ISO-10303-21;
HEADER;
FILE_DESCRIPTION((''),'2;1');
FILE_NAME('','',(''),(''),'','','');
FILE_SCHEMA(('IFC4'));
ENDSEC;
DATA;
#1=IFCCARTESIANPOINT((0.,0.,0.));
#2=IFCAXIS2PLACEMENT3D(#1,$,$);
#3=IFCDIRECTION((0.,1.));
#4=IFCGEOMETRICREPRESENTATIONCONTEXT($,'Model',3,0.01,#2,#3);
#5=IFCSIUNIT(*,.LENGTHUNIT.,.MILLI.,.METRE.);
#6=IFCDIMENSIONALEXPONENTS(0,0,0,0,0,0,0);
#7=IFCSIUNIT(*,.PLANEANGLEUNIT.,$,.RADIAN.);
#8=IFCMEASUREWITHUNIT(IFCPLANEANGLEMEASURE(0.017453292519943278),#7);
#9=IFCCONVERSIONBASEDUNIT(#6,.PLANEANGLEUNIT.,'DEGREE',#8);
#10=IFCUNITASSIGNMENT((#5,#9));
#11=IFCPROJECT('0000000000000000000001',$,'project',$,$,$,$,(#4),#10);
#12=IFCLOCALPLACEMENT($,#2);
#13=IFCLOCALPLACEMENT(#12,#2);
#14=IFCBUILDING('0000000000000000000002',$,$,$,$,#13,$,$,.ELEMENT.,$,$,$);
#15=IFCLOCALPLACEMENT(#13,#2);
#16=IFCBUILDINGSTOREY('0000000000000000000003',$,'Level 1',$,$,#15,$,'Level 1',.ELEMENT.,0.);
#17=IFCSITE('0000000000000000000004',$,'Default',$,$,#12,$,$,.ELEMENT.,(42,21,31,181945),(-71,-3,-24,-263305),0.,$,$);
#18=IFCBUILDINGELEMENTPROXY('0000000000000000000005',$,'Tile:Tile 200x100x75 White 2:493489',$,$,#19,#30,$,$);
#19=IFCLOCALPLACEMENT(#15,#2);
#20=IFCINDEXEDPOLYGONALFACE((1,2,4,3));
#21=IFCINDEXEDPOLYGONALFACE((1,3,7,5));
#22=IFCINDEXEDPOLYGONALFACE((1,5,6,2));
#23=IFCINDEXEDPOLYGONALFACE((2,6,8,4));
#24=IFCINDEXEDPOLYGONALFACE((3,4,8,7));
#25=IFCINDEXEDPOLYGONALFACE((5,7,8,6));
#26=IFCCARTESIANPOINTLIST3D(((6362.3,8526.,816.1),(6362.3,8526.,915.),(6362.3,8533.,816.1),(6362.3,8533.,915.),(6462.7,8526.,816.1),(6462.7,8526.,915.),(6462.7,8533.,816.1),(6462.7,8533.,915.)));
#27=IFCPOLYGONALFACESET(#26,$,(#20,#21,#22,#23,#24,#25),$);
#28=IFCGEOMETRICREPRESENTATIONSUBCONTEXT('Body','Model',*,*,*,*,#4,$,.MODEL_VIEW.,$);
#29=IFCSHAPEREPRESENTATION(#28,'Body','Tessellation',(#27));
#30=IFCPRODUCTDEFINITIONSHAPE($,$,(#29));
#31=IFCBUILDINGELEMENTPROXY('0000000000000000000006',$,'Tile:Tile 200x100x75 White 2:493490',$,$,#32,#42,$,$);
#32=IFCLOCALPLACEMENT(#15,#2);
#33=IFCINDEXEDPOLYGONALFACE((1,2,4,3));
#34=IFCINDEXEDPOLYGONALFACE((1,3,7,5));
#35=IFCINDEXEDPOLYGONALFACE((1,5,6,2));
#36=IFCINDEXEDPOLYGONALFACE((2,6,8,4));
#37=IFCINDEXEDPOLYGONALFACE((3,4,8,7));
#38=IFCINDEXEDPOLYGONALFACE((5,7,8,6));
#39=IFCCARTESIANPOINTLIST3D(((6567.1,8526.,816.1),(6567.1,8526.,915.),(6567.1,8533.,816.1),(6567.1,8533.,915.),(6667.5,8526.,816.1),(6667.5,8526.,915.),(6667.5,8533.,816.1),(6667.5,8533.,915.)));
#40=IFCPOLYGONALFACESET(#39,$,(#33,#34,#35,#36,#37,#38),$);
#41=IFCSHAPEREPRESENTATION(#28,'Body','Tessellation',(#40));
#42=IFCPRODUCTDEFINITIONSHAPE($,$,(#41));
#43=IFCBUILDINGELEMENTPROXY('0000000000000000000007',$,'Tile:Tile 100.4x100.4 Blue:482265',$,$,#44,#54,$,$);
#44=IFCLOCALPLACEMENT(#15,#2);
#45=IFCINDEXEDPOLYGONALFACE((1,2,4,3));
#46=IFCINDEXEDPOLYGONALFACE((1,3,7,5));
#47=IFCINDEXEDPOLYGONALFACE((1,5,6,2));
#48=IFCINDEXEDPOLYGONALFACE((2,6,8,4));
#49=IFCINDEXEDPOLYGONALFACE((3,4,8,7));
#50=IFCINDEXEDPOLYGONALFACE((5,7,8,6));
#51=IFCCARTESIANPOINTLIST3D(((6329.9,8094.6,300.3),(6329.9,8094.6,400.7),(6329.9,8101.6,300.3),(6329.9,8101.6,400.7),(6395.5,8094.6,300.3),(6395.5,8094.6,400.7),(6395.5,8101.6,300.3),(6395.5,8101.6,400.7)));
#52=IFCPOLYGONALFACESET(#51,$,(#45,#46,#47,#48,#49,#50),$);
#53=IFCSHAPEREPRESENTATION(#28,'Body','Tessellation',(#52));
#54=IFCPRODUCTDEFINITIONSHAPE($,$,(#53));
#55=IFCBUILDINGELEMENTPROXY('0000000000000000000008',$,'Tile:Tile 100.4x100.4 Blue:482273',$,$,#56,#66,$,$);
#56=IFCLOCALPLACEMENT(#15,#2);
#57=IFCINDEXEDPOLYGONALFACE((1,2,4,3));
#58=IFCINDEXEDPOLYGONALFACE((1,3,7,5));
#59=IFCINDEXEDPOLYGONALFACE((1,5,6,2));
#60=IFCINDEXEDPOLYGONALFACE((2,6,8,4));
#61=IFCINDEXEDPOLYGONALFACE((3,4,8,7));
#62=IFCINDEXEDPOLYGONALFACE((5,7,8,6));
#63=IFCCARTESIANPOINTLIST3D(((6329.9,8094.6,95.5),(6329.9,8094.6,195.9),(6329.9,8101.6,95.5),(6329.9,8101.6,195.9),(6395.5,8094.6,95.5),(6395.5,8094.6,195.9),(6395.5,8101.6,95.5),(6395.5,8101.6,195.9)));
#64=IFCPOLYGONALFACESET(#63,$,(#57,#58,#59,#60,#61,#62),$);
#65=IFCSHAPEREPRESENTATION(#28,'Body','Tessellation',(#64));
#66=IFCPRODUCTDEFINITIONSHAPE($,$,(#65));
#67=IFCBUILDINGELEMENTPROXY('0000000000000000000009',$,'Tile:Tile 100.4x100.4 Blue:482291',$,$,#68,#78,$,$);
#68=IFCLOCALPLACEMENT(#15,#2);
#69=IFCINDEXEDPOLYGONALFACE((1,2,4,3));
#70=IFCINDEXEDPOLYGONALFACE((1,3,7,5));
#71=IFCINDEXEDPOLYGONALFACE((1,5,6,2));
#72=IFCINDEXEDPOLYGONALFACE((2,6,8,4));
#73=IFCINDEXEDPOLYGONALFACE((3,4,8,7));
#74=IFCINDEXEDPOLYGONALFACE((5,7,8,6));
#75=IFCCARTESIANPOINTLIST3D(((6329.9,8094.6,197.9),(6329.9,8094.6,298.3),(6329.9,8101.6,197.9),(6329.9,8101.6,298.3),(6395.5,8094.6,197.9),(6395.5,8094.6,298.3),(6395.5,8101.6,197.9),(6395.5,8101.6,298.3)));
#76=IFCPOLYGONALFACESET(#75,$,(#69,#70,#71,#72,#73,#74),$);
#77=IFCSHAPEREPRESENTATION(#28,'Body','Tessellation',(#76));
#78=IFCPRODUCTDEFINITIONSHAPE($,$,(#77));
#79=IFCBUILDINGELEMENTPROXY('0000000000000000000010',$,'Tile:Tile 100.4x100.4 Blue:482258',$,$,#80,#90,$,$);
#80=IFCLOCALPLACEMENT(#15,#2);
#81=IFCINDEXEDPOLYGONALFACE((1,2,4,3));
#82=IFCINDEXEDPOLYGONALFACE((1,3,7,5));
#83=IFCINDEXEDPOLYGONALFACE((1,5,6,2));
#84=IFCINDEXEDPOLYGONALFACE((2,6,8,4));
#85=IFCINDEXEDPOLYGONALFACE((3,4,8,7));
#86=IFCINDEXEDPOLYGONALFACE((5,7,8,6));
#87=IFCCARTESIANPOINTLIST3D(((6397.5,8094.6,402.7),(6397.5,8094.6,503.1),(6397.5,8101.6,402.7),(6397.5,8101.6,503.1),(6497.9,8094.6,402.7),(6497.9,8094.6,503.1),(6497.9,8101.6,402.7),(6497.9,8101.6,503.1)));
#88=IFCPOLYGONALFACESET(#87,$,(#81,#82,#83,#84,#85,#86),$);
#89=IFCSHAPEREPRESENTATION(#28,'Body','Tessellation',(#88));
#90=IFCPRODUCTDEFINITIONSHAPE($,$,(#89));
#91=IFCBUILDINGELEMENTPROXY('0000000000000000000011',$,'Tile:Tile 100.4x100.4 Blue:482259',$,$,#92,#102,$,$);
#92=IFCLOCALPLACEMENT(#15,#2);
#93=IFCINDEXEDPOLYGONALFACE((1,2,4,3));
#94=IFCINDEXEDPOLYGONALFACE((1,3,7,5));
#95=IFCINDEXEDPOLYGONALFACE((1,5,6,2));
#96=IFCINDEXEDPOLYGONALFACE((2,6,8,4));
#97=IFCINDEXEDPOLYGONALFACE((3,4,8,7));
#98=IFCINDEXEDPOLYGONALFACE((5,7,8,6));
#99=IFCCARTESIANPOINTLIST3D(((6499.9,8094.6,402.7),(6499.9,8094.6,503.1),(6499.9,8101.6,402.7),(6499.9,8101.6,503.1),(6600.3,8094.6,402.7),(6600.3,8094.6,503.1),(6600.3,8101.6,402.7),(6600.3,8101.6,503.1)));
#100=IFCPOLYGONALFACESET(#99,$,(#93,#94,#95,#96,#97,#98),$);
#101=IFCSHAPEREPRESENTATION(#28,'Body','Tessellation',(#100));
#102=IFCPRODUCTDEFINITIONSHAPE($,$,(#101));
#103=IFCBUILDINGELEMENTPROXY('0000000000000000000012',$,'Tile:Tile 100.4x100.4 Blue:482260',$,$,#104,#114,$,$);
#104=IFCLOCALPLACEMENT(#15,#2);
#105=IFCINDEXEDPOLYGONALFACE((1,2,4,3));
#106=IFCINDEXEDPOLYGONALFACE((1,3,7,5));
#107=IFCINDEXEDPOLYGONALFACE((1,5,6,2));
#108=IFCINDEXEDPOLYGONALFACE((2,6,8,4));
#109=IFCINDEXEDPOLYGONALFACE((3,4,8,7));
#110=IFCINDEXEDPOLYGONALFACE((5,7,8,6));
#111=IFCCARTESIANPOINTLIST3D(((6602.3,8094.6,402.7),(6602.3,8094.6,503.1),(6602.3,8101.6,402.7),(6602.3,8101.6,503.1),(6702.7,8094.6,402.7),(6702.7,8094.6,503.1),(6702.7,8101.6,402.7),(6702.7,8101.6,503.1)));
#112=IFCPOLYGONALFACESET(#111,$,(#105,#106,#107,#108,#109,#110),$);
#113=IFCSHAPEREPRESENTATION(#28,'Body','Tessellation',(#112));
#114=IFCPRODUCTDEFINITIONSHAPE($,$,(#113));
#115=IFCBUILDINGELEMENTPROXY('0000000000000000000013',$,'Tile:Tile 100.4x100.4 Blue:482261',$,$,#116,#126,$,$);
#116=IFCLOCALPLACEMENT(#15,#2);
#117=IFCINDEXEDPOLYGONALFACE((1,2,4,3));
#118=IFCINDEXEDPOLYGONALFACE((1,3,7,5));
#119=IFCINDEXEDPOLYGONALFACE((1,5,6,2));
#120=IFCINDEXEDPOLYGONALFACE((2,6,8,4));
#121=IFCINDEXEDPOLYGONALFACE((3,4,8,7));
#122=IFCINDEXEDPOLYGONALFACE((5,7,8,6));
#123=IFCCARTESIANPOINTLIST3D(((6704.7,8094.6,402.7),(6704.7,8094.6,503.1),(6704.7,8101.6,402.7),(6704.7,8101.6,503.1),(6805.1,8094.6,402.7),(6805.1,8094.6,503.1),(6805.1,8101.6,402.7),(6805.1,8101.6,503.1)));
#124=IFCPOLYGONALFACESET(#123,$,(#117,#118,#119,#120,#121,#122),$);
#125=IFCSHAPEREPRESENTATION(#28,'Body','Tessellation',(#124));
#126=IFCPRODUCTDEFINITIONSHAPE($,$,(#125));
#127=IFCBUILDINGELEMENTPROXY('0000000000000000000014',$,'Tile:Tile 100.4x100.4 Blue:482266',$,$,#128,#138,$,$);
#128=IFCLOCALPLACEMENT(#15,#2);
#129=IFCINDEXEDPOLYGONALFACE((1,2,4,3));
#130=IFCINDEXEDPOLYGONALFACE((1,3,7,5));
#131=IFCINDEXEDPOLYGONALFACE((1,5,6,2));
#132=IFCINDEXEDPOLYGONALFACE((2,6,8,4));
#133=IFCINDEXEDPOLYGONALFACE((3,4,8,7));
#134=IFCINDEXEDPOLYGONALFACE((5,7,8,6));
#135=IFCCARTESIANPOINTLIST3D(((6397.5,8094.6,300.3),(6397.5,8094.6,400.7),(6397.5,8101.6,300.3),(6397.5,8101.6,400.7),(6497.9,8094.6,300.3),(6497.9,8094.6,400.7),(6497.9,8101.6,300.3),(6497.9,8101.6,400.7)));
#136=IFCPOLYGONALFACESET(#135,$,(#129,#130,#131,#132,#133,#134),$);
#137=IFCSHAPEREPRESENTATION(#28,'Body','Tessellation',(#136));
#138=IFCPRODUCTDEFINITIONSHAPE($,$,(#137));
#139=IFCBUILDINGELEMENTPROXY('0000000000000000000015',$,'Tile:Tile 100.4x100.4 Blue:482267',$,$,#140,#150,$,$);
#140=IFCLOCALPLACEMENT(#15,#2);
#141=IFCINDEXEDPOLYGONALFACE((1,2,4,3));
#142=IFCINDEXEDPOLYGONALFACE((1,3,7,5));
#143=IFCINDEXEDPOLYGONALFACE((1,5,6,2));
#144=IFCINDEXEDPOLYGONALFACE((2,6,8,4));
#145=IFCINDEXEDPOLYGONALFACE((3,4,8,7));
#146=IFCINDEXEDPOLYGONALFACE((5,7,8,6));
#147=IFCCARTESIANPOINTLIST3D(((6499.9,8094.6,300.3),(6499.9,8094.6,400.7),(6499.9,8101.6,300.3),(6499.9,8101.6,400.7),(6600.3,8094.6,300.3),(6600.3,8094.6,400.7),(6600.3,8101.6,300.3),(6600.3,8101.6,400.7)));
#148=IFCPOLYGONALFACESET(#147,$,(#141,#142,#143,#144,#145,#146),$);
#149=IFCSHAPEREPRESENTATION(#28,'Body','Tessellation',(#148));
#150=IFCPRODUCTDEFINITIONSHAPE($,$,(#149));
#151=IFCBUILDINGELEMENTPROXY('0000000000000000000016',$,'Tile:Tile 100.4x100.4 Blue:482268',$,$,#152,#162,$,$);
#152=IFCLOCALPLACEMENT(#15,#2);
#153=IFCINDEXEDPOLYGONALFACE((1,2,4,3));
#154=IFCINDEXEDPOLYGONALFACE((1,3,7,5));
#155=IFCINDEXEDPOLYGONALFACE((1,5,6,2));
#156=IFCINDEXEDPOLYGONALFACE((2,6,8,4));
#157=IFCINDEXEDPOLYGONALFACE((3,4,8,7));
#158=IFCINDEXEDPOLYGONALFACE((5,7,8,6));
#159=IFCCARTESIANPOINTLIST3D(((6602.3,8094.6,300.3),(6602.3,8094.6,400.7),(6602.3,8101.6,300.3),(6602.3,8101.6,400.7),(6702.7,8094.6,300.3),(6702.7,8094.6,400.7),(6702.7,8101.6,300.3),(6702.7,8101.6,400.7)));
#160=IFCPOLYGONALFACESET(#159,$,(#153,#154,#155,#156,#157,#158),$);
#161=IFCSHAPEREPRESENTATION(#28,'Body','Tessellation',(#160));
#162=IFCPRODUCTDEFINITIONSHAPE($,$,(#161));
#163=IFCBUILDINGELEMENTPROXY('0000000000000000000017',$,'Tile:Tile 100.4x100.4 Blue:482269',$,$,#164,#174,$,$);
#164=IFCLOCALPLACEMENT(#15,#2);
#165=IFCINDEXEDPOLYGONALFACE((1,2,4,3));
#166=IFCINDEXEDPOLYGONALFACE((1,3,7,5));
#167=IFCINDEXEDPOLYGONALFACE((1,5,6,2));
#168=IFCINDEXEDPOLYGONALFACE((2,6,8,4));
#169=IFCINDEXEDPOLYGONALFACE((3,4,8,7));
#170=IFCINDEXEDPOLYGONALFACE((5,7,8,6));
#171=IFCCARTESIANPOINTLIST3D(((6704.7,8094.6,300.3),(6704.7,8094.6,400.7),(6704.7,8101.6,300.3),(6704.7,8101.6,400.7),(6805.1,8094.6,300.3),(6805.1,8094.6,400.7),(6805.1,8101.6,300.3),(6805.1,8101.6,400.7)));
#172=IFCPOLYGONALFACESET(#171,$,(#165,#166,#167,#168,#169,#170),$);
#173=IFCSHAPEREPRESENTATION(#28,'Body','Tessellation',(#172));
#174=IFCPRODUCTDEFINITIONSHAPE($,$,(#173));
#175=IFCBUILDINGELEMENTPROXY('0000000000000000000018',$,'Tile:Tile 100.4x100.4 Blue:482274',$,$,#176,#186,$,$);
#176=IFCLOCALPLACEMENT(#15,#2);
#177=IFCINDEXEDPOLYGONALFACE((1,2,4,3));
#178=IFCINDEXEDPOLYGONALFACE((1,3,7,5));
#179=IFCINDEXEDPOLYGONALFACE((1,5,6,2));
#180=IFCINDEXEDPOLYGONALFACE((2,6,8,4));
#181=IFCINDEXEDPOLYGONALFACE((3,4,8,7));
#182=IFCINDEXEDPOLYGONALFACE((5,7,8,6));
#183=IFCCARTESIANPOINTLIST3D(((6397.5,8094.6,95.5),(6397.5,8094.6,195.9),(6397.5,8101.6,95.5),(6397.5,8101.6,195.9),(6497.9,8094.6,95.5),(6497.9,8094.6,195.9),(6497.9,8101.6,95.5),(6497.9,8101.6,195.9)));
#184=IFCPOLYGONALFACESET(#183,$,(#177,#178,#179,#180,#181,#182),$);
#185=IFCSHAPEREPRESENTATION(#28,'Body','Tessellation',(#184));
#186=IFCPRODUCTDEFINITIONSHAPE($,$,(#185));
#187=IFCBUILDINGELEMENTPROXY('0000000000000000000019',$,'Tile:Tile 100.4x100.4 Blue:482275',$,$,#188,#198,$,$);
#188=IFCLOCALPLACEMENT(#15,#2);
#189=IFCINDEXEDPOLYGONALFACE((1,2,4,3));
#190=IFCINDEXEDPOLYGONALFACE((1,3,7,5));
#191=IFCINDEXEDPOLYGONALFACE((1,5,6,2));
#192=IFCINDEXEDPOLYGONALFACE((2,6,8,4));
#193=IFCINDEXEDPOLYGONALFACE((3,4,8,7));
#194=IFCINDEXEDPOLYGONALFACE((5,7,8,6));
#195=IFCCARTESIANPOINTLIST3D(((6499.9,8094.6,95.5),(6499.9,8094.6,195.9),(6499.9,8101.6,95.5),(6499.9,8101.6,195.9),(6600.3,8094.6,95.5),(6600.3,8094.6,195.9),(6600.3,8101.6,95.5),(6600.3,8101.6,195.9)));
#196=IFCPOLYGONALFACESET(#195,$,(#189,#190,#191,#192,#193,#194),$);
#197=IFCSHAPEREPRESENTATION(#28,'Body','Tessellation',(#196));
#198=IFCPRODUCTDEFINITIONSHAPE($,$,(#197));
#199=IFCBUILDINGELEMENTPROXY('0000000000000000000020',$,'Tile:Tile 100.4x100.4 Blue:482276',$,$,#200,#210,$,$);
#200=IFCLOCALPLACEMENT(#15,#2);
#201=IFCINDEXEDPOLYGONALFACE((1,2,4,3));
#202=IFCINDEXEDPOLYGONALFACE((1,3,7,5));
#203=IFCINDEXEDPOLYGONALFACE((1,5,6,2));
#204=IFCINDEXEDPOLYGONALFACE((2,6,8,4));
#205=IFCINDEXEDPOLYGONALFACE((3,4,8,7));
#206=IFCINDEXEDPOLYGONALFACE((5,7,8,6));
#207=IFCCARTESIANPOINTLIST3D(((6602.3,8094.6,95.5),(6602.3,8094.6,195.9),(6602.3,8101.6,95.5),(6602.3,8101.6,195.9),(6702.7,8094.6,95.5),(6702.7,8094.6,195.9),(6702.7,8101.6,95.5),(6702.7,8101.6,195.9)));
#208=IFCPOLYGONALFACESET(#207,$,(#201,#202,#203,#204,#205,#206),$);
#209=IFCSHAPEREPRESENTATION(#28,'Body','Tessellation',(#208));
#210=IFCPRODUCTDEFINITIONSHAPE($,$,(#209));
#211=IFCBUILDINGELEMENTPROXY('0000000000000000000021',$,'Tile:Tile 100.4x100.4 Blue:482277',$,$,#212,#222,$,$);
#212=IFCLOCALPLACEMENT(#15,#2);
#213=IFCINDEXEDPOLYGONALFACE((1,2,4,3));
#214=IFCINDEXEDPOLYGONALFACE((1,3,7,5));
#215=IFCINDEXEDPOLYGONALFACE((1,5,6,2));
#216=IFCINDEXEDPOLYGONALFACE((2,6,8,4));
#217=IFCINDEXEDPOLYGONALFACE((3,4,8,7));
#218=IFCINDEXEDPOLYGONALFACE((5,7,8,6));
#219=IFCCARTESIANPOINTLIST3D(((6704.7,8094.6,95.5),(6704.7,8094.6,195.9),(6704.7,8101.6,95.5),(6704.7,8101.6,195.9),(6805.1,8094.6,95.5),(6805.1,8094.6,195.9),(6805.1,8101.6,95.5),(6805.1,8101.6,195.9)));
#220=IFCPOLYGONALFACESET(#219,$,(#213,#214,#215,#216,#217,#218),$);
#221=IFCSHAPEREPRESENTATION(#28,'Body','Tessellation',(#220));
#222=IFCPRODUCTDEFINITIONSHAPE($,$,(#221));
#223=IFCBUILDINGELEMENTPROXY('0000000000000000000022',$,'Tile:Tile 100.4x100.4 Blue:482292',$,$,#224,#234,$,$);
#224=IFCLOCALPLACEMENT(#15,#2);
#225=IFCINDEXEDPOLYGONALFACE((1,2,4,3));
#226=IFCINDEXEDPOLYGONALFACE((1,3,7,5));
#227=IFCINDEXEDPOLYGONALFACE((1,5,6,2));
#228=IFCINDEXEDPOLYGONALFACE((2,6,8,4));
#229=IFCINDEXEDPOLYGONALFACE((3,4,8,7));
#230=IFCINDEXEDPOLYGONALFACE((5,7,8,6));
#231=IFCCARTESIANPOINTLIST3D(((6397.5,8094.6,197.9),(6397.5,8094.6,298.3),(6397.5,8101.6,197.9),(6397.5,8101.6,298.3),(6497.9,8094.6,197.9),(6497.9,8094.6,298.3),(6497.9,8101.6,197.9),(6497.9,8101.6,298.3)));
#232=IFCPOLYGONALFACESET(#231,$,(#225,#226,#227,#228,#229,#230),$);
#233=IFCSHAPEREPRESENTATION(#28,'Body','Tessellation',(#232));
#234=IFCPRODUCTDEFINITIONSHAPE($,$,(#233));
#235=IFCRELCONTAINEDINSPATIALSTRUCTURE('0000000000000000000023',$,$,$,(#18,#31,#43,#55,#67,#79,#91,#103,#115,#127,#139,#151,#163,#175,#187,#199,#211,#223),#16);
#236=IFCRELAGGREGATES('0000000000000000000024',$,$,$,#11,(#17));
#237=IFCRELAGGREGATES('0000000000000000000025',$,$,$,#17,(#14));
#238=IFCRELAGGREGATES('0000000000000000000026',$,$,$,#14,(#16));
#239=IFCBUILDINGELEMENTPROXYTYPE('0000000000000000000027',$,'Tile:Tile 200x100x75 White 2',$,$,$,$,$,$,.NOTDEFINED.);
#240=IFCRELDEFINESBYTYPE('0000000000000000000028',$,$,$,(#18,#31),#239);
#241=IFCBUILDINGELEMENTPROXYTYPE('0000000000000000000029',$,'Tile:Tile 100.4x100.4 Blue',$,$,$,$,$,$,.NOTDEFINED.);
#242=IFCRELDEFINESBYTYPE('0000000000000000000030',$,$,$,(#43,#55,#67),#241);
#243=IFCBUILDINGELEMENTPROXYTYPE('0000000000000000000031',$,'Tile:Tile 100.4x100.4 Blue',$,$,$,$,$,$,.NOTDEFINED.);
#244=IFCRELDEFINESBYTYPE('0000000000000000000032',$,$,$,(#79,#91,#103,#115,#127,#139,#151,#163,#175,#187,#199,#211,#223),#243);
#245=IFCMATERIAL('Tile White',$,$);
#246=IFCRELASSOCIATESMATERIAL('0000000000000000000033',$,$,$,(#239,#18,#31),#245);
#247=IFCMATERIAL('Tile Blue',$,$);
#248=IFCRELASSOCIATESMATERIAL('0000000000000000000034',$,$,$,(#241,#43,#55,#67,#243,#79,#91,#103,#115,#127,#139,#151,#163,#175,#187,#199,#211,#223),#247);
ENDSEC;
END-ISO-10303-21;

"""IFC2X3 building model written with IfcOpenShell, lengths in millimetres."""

from ifc_helpers import new_model, entity, si_unit, converted_unit, direction, frame, frame_2d, origin, origin_2d_with_axis, place, context, subcontext, project, spatial, rectangle, extrude, source, transform, mapped, material, type_object, type_shapes, element, save


model = new_model("IFC2X3")

# Units and contexts
model_context = context("Model", 3, precision=0.01, world=origin(), true_north=direction((0.0, 1.0)))
body_context = subcontext(model_context, "Body", "Model", "MODEL_VIEW")
ifc_project = project(units=[si_unit("LENGTHUNIT", "METRE", prefix="MILLI"), converted_unit("PLANEANGLEUNIT", "DEGREE", entity("IfcPlaneAngleMeasure", 0.017453292519943278), si_unit("PLANEANGLEUNIT", "RADIAN"), dimensions=[0, 0, 0, 0, 0, 0, 0])], contexts=[model_context])

# Site, building, storey
site_placement = place(None, origin())
site = spatial("IfcSite", under=ifc_project, at=site_placement, Name="Default", CompositionType="ELEMENT", RefLatitude=(42, 21, 31, 181945), RefLongitude=(-71, -3, -24, -263305), RefElevation=0.0)
building_placement = place(site_placement, origin())
building = spatial("IfcBuilding", under=site, at=building_placement, CompositionType="ELEMENT")
storey_placement = place(building_placement, origin())
storey = spatial("IfcBuildingStorey", under=building, at=storey_placement, Name="Level 1", LongName="Level 1", CompositionType="ELEMENT", Elevation=0.0)

# Building element proxies
ifc_material_1 = material(Name="Tile White")
building_element_proxy_type_1 = type_object("IfcBuildingElementProxyType", Name="Tile:Tile 200x100x75 White 2", PredefinedType="NOTDEFINED", material=ifc_material_1)
shared_shape_1 = source(origin(), body_context, "Body", "SweptSolid", [
    extrude(rectangle(XDim=98.9, YDim=100.4, at=origin_2d_with_axis()), frame((-50.2, -49.5, 0.0), z_axis=(0.0, 0.0, 1.0), x_axis=(0.0, -1.0, 0.0)), (0.0, 0.0, 1.0), 7.0),
])
type_shapes(building_element_proxy_type_1, [shared_shape_1])
for number, where, z_axis, x_axis, name in (
    (1, (6462.7, 8533.0, 915.0), (0.0, -1.0, 0.0), (1.0, 0.0, 0.0), "Tile:Tile 200x100x75 White 2:493489"),
    (2, (6667.5, 8533.0, 915.0), (0.0, -1.0, 0.0), (1.0, 0.0, 0.0), "Tile:Tile 200x100x75 White 2:493490"),
):
    element("IfcBuildingElementProxy", number, at=place(storey_placement, frame(where, z_axis=z_axis, x_axis=x_axis)), inside=storey, type_object=building_element_proxy_type_1, material=ifc_material_1, Name=name, context=body_context, shape_type="MappedRepresentation", body=[
        mapped(shared_shape_1, transform((0.0, 0.0, 0.0), scale=1.0)),
    ])
ifc_material_2 = material(Name="Tile Blue")
building_element_proxy_type_2 = type_object("IfcBuildingElementProxyType", Name="Tile:Tile 100.4x100.4 Blue", PredefinedType="NOTDEFINED", material=ifc_material_2)
shared_shape_2 = source(origin(), body_context, "Body", "SweptSolid", [
    extrude(rectangle(XDim=65.6, YDim=100.4, at=frame_2d((0.0, 0.0), x_axis=(1.0, 0.0))), frame((-32.8, -50.2, 0.0), z_axis=(0.0, 0.0, 1.0), x_axis=(-1.0, 0.0, 0.0)), (0.0, 0.0, 1.0), 7.0),
])
type_shapes(building_element_proxy_type_2, [shared_shape_2])
for number, where, z_axis, x_axis, name in (
    (3, (6329.9, 8101.6, 300.3), (0.0, -1.0, 0.0), (-1.0, 0.0, 0.0), "Tile:Tile 100.4x100.4 Blue:482265"),
    (4, (6329.9, 8101.6, 95.5), (0.0, -1.0, 0.0), (-1.0, 0.0, 0.0), "Tile:Tile 100.4x100.4 Blue:482273"),
    (5, (6329.9, 8101.6, 197.9), (0.0, -1.0, 0.0), (-1.0, 0.0, 0.0), "Tile:Tile 100.4x100.4 Blue:482291"),
):
    element("IfcBuildingElementProxy", number, at=place(storey_placement, frame(where, z_axis=z_axis, x_axis=x_axis)), inside=storey, type_object=building_element_proxy_type_2, material=ifc_material_2, Name=name, context=body_context, shape_type="MappedRepresentation", body=[
        mapped(shared_shape_2, transform((0.0, 0.0, 0.0), scale=1.0)),
    ])
building_element_proxy_type_3 = type_object("IfcBuildingElementProxyType", Name="Tile:Tile 100.4x100.4 Blue", PredefinedType="NOTDEFINED", material=ifc_material_2)
shared_shape_3 = source(origin(), body_context, "Body", "SweptSolid", [
    extrude(rectangle(XDim=100.4, YDim=100.4, at=origin_2d_with_axis()), frame((-50.2, -50.2, 0.0), z_axis=(0.0, 0.0, 1.0), x_axis=(0.0, -1.0, 0.0)), (0.0, 0.0, 1.0), 7.0),
])
type_shapes(building_element_proxy_type_3, [shared_shape_3])
for number, where, z_axis, x_axis, name in (
    (6, (6397.5, 8101.6, 402.7), (0.0, -1.0, 0.0), (-1.0, 0.0, 0.0), "Tile:Tile 100.4x100.4 Blue:482258"),
    (7, (6499.9, 8101.6, 402.7), (0.0, -1.0, 0.0), (-1.0, 0.0, 0.0), "Tile:Tile 100.4x100.4 Blue:482259"),
    (8, (6602.3, 8101.6, 402.7), (0.0, -1.0, 0.0), (-1.0, 0.0, 0.0), "Tile:Tile 100.4x100.4 Blue:482260"),
    (9, (6704.7, 8101.6, 402.7), (0.0, -1.0, 0.0), (-1.0, 0.0, 0.0), "Tile:Tile 100.4x100.4 Blue:482261"),
    (10, (6397.5, 8101.6, 300.3), (0.0, -1.0, 0.0), (-1.0, 0.0, 0.0), "Tile:Tile 100.4x100.4 Blue:482266"),
    (11, (6499.9, 8101.6, 300.3), (0.0, -1.0, 0.0), (-1.0, 0.0, 0.0), "Tile:Tile 100.4x100.4 Blue:482267"),
    (12, (6602.3, 8101.6, 300.3), (0.0, -1.0, 0.0), (-1.0, 0.0, 0.0), "Tile:Tile 100.4x100.4 Blue:482268"),
    (13, (6704.7, 8101.6, 300.3), (0.0, -1.0, 0.0), (-1.0, 0.0, 0.0), "Tile:Tile 100.4x100.4 Blue:482269"),
    (14, (6397.5, 8101.6, 95.5), (0.0, -1.0, 0.0), (-1.0, 0.0, 0.0), "Tile:Tile 100.4x100.4 Blue:482274"),
    (15, (6499.9, 8101.6, 95.5), (0.0, -1.0, 0.0), (-1.0, 0.0, 0.0), "Tile:Tile 100.4x100.4 Blue:482275"),
    (16, (6602.3, 8101.6, 95.5), (0.0, -1.0, 0.0), (-1.0, 0.0, 0.0), "Tile:Tile 100.4x100.4 Blue:482276"),
    (17, (6704.7, 8101.6, 95.5), (0.0, -1.0, 0.0), (-1.0, 0.0, 0.0), "Tile:Tile 100.4x100.4 Blue:482277"),
    (18, (6397.5, 8101.6, 197.9), (0.0, -1.0, 0.0), (-1.0, 0.0, 0.0), "Tile:Tile 100.4x100.4 Blue:482292"),
):
    element("IfcBuildingElementProxy", number, at=place(storey_placement, frame(where, z_axis=z_axis, x_axis=x_axis)), inside=storey, type_object=building_element_proxy_type_3, material=ifc_material_2, Name=name, context=body_context, shape_type="MappedRepresentation", body=[
        mapped(shared_shape_3, transform((0.0, 0.0, 0.0), scale=1.0)),
    ])

save(model, "model.ifc")
